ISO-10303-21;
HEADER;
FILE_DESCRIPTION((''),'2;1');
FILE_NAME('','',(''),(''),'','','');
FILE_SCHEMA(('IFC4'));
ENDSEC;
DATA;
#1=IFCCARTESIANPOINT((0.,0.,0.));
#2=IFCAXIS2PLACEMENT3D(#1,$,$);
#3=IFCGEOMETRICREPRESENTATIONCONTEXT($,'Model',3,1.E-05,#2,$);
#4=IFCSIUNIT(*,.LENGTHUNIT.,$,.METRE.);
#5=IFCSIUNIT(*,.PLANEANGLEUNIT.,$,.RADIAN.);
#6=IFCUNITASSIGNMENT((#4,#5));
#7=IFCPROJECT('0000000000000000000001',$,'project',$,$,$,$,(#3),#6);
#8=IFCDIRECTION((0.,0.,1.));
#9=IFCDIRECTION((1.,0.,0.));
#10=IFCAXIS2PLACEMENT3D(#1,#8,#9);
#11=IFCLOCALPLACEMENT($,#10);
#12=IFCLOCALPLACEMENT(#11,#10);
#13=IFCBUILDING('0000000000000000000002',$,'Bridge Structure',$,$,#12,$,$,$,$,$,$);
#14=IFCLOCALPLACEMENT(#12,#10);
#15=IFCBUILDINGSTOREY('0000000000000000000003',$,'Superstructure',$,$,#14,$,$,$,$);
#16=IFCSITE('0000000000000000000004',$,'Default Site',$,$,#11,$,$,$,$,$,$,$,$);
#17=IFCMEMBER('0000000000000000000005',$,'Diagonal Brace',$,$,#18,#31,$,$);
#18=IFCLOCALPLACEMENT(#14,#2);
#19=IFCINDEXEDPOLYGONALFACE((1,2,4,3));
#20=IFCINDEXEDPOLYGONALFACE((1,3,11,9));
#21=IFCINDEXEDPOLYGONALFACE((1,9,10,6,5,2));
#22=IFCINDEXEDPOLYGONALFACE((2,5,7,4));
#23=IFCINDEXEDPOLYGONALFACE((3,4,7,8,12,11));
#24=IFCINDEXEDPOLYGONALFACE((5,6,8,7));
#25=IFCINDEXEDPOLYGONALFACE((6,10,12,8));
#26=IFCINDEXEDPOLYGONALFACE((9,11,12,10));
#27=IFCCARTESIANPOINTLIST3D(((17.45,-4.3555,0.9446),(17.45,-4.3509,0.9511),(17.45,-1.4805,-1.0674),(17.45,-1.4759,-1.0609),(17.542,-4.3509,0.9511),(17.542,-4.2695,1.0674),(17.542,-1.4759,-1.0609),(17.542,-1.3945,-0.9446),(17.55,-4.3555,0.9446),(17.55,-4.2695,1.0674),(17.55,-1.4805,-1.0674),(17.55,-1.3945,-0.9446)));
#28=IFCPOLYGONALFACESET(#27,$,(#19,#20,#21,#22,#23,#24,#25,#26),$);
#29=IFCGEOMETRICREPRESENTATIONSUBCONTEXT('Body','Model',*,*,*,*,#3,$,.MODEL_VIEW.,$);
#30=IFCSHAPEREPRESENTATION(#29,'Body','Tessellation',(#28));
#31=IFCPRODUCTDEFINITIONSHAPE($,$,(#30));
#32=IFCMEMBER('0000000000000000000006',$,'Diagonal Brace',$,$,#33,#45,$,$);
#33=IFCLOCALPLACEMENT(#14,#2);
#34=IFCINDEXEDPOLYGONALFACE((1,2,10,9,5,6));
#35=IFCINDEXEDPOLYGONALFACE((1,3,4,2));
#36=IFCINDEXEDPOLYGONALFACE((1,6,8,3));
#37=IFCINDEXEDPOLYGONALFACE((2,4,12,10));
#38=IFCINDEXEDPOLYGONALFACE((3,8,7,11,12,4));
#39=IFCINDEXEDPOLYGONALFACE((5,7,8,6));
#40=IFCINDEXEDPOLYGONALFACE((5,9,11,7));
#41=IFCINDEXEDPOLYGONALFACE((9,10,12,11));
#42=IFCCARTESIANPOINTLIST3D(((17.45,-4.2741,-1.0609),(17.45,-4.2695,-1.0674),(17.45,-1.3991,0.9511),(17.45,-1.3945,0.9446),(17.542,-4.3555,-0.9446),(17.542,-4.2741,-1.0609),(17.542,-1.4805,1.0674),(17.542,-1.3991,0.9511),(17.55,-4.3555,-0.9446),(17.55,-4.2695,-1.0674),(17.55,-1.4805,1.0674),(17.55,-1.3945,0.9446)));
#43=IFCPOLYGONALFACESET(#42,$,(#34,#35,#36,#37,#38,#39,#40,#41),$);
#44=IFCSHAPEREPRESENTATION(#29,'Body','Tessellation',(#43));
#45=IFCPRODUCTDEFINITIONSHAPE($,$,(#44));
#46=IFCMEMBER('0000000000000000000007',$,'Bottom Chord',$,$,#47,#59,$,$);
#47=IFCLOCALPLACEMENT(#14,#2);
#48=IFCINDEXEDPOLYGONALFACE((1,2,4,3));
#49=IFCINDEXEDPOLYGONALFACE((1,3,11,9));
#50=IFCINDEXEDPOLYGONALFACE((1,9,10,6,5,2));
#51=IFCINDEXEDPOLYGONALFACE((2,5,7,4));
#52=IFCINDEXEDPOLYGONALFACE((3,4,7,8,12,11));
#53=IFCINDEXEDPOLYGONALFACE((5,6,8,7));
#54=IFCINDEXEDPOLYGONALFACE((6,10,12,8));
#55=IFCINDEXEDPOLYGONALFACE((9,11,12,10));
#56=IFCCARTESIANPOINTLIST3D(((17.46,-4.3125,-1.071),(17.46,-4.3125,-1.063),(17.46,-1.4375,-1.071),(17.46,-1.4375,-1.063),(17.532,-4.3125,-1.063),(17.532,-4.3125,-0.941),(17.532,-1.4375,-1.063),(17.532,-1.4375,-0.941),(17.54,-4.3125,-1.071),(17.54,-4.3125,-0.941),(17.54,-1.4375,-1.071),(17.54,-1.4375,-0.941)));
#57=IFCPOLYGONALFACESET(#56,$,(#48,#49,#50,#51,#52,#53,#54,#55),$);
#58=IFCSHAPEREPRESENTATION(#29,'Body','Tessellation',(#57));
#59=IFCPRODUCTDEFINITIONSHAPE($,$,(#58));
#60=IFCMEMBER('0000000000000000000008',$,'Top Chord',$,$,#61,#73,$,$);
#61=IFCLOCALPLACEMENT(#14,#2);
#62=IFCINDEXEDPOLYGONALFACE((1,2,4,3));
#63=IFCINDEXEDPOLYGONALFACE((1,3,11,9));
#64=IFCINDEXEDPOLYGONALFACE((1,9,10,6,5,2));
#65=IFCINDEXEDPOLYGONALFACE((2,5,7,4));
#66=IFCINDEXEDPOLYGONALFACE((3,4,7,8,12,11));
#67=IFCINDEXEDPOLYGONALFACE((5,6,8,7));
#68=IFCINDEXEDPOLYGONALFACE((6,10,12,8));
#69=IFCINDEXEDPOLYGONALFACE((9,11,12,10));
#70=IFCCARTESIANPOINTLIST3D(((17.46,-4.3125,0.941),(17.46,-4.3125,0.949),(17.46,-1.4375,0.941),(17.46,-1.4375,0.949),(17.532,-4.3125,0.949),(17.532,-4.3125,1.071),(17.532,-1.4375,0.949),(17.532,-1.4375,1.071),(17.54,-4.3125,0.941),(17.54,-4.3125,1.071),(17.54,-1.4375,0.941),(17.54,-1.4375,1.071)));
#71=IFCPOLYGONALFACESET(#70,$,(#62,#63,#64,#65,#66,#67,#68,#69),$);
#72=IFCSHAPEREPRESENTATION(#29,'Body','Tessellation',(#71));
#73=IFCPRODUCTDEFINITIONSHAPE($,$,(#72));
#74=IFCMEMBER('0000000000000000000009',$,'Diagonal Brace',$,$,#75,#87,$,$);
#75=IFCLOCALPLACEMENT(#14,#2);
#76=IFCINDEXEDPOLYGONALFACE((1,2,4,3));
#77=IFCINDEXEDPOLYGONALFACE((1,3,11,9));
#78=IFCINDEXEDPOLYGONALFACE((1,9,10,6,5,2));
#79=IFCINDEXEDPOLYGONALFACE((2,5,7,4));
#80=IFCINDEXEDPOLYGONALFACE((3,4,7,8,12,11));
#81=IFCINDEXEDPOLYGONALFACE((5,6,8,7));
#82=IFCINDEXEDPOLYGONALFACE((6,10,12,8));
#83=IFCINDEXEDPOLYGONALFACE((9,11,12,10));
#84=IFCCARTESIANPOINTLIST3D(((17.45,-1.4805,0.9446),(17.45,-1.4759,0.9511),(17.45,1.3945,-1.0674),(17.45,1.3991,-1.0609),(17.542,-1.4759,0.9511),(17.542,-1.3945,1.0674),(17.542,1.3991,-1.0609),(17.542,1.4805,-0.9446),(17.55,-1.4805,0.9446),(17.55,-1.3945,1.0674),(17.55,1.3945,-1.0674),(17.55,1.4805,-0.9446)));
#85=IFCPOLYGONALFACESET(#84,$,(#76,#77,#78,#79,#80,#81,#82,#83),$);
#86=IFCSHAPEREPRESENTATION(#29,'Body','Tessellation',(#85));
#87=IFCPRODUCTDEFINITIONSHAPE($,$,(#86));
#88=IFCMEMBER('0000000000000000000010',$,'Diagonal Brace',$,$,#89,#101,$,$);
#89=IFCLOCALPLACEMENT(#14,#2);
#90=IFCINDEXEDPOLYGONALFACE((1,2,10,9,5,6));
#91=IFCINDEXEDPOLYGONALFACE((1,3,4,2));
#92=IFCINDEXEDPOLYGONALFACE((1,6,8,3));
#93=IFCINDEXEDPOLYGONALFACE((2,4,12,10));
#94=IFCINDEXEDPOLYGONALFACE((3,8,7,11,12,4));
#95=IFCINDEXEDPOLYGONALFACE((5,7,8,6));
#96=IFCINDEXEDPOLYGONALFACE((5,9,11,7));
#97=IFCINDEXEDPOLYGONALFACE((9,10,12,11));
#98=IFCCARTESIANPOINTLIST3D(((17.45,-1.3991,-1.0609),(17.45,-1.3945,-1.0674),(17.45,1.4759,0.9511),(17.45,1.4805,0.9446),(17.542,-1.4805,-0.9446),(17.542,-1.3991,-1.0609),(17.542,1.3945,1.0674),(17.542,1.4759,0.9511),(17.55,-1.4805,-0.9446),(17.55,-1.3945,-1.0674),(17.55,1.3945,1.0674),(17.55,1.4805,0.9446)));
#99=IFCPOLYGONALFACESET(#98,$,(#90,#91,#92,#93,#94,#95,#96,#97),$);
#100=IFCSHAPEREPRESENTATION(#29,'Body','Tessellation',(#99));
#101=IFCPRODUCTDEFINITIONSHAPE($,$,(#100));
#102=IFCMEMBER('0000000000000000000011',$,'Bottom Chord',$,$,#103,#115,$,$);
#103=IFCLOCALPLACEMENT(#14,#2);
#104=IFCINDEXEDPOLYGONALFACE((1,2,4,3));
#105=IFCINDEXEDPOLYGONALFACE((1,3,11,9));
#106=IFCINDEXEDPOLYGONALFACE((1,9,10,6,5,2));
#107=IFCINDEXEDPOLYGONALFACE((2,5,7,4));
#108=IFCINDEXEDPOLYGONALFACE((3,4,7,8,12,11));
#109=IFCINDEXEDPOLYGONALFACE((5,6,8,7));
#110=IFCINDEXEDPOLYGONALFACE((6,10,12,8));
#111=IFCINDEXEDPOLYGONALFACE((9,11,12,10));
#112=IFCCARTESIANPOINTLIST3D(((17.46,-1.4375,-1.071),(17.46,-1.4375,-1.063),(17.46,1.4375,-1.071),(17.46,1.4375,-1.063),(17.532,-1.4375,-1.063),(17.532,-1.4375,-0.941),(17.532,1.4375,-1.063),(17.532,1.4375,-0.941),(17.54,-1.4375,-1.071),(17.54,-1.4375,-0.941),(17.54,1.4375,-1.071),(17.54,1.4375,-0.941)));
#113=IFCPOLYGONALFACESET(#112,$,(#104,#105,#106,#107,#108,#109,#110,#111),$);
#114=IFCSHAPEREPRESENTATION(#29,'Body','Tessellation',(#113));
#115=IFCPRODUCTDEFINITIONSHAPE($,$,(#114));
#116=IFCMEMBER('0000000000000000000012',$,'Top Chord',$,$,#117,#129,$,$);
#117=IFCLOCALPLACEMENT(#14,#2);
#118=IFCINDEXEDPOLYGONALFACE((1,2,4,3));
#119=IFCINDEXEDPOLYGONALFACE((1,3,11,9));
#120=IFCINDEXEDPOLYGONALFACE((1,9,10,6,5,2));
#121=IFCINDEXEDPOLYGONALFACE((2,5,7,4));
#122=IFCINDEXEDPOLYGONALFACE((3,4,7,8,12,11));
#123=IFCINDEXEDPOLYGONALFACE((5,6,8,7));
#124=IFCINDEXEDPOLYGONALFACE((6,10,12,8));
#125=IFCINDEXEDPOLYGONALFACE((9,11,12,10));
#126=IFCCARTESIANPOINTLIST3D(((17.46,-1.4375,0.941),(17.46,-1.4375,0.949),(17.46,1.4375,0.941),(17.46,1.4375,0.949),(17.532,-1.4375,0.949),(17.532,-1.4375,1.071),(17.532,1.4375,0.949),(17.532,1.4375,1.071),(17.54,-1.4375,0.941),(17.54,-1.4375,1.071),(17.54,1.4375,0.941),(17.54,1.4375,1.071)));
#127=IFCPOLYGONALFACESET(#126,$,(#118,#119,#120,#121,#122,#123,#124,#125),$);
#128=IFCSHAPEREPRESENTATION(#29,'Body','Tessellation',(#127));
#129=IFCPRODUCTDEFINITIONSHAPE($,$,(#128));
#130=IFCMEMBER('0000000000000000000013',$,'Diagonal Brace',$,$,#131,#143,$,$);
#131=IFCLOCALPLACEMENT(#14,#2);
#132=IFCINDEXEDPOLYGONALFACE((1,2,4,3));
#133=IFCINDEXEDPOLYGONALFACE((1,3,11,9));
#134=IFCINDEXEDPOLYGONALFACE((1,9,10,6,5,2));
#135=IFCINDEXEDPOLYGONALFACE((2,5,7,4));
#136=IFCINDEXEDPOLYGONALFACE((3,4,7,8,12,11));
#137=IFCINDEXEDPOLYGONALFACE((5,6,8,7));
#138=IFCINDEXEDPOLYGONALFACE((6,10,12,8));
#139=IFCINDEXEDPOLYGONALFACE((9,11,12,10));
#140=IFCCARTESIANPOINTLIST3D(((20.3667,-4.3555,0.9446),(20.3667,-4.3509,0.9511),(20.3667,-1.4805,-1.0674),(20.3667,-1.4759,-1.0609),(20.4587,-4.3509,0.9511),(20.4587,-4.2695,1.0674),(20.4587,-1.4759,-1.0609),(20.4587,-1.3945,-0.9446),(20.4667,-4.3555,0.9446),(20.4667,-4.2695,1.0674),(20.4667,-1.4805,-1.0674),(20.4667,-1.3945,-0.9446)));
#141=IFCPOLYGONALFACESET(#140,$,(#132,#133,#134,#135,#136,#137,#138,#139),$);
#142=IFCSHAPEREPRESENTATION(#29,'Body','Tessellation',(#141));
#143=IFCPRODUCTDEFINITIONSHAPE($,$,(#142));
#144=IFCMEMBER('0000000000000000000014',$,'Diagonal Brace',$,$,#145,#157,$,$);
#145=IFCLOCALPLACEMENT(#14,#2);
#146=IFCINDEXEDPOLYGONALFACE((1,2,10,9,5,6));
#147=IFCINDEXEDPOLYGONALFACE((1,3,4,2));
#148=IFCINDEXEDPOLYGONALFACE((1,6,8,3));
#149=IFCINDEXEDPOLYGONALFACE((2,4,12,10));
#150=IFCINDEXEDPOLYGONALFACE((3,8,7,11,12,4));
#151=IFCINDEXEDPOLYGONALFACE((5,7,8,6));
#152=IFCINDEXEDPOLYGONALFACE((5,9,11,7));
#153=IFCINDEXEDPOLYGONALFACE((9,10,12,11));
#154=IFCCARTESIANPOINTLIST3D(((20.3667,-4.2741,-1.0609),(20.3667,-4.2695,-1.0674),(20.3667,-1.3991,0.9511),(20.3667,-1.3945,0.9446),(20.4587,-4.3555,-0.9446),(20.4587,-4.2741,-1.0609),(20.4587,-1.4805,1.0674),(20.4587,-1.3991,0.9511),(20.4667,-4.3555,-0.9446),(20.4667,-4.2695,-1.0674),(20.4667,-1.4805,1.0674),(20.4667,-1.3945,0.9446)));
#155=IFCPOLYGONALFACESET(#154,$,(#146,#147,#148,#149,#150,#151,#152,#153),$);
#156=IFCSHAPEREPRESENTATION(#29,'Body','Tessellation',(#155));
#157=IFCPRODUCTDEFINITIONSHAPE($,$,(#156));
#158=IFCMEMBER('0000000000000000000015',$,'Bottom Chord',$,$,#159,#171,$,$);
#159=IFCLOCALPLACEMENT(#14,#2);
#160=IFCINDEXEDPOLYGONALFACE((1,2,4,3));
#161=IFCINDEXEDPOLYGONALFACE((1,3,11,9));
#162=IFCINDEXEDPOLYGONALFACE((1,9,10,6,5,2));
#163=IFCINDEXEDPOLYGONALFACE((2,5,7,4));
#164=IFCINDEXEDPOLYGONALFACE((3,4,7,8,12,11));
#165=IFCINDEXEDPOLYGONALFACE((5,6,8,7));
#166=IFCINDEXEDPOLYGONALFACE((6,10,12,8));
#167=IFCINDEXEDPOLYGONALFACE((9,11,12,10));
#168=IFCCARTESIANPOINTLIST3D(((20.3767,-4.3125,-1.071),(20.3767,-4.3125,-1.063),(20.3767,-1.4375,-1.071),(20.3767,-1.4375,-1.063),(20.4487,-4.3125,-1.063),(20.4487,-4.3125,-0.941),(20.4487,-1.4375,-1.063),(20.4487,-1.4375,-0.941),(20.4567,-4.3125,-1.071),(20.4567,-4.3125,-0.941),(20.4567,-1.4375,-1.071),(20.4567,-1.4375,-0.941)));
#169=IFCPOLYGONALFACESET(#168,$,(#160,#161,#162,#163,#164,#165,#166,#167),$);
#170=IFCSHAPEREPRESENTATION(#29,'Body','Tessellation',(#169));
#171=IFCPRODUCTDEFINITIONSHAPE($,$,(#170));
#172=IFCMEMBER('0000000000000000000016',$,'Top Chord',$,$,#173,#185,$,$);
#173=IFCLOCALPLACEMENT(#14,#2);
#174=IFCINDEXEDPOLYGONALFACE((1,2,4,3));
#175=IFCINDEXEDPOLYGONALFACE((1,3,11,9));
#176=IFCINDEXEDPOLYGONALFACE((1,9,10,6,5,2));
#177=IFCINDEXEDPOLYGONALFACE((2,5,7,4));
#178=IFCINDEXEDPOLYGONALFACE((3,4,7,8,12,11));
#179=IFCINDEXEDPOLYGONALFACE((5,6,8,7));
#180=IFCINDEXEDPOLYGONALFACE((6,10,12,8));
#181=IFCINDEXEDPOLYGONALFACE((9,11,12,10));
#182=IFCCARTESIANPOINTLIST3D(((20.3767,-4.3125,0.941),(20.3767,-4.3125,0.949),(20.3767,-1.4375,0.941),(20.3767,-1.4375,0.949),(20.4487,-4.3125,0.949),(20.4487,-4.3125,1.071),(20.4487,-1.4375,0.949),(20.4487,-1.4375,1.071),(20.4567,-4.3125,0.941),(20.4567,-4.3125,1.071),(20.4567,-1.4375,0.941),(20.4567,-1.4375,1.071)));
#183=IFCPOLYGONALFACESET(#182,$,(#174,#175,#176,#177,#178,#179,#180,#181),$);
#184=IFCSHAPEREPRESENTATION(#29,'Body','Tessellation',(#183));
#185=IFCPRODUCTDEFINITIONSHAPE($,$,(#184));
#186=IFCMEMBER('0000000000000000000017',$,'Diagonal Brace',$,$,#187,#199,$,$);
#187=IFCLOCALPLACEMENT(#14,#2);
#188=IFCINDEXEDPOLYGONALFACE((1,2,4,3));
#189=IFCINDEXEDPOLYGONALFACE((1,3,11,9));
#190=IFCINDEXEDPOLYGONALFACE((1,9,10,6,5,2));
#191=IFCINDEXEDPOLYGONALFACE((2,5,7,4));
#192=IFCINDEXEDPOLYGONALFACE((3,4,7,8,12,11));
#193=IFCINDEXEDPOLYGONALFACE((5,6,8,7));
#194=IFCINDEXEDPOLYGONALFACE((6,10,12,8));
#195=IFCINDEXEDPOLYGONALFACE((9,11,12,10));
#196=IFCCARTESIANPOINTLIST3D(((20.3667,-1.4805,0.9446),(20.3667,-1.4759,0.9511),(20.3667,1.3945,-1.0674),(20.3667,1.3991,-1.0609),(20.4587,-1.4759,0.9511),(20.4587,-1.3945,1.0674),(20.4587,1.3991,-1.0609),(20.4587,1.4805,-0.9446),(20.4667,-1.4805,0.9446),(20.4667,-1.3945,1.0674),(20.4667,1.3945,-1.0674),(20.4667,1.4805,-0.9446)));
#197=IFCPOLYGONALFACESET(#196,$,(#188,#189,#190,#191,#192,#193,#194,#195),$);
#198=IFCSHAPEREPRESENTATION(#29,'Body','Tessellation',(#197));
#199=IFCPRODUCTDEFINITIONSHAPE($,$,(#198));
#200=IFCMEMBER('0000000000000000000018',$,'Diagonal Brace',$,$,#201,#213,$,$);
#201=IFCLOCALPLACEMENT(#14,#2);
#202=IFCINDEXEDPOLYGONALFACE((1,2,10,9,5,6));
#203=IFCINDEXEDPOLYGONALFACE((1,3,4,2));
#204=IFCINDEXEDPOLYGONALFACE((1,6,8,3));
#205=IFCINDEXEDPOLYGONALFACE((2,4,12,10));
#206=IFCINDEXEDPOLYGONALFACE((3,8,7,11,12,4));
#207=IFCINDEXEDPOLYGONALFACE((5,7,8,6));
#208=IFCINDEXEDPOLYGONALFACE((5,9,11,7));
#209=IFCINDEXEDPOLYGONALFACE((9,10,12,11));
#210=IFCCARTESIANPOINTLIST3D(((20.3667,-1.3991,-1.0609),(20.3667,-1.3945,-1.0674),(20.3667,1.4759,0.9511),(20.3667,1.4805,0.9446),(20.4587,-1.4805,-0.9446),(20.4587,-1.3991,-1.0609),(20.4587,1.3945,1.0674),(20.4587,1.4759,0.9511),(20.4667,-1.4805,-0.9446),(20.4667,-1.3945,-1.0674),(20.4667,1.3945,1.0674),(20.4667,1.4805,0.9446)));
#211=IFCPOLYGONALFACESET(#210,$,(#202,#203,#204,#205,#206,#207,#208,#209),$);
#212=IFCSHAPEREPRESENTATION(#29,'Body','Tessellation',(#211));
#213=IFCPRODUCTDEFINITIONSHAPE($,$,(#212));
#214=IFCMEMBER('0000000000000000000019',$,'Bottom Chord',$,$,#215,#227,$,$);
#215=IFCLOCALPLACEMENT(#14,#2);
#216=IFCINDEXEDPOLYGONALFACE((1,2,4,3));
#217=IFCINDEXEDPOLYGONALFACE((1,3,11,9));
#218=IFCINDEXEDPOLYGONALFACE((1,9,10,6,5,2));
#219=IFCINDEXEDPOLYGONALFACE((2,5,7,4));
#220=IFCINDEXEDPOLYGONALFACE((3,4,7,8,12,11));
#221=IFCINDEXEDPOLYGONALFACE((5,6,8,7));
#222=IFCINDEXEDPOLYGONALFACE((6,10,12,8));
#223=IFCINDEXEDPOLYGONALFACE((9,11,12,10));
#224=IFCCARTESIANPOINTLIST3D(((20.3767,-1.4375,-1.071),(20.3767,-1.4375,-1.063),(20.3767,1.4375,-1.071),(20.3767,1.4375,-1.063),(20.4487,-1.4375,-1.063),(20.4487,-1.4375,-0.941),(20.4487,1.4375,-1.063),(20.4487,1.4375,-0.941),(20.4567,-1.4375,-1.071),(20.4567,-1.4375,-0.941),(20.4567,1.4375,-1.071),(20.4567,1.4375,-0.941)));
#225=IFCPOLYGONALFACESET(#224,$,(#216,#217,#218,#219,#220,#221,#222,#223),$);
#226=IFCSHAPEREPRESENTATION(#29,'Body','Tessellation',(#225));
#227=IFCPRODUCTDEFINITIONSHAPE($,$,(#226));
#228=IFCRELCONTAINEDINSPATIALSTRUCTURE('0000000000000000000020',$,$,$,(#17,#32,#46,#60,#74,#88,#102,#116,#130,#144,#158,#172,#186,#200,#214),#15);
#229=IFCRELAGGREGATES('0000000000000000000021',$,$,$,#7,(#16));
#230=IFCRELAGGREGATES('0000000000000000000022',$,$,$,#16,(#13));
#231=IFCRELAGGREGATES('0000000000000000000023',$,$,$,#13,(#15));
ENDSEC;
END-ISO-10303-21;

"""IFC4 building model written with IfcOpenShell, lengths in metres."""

from ifc_helpers import new_model, si_unit, frame, origin, origin_with_axes, origin_2d_with_axis, place, context, subcontext, project, spatial, l_section, extrude, element, save


model = new_model("IFC4")

# Units and contexts
model_context = context("Model", 3, precision=1e-05, world=origin())
body_context = subcontext(model_context, "Body", "Model", "MODEL_VIEW")
ifc_project = project(units=[si_unit("LENGTHUNIT", "METRE"), si_unit("PLANEANGLEUNIT", "RADIAN")], contexts=[model_context])

# Site, building, storey
site_placement = place(None, origin_with_axes())
site = spatial("IfcSite", under=ifc_project, at=site_placement, Name="Default Site")
building_placement = place(site_placement, origin_with_axes())
building = spatial("IfcBuilding", under=site, at=building_placement, Name="Bridge Structure")
storey_placement = place(building_placement, origin_with_axes())
storey = spatial("IfcBuildingStorey", under=building, at=storey_placement, Name="Superstructure")

# Members
for number, where, z_axis, x_axis, name in (
    (1, (17.5, -4.3125, 1.006), (0.0, 0.819299, -0.573367), (-1.0, 0.0, 0.0), "Diagonal Brace"),
    (2, (17.5, -4.3125, -1.006), (0.0, 0.819299, 0.573367), (-1.0, 0.0, 0.0), "Diagonal Brace"),
):
    element("IfcMember", number, at=place(storey_placement, frame(where, z_axis=z_axis, x_axis=x_axis)), inside=storey, Name=name, context=body_context, shape_type="SweptSolid", body=[
        extrude(l_section(Depth=0.15, Width=0.1, Thickness=0.008, at=origin_2d_with_axis()), origin_with_axes(), (0.0, 0.0, 1.0), 3.5091),
    ])
for number, where, z_axis, x_axis, name in (
    (3, (17.5, -4.3125, -1.006), (0.0, 1.0, 0.0), (-1.0, 0.0, 0.0), "Bottom Chord"),
    (4, (17.5, -4.3125, 1.006), (0.0, 1.0, 0.0), (-1.0, 0.0, 0.0), "Top Chord"),
):
    element("IfcMember", number, at=place(storey_placement, frame(where, z_axis=z_axis, x_axis=x_axis)), inside=storey, Name=name, context=body_context, shape_type="SweptSolid", body=[
        extrude(l_section(Depth=0.13, Width=0.08, Thickness=0.008, at=origin_2d_with_axis()), origin_with_axes(), (0.0, 0.0, 1.0), 2.875),
    ])
for number, where, z_axis, x_axis, name in (
    (5, (17.5, -1.4375, 1.006), (0.0, 0.819299, -0.573367), (-1.0, 0.0, 0.0), "Diagonal Brace"),
    (6, (17.5, -1.4375, -1.006), (0.0, 0.819299, 0.573367), (-1.0, 0.0, 0.0), "Diagonal Brace"),
):
    element("IfcMember", number, at=place(storey_placement, frame(where, z_axis=z_axis, x_axis=x_axis)), inside=storey, Name=name, context=body_context, shape_type="SweptSolid", body=[
        extrude(l_section(Depth=0.15, Width=0.1, Thickness=0.008, at=origin_2d_with_axis()), origin_with_axes(), (0.0, 0.0, 1.0), 3.5091),
    ])
for number, where, z_axis, x_axis, name in (
    (7, (17.5, -1.4375, -1.006), (0.0, 1.0, 0.0), (-1.0, 0.0, 0.0), "Bottom Chord"),
    (8, (17.5, -1.4375, 1.006), (0.0, 1.0, 0.0), (-1.0, 0.0, 0.0), "Top Chord"),
):
    element("IfcMember", number, at=place(storey_placement, frame(where, z_axis=z_axis, x_axis=x_axis)), inside=storey, Name=name, context=body_context, shape_type="SweptSolid", body=[
        extrude(l_section(Depth=0.13, Width=0.08, Thickness=0.008, at=origin_2d_with_axis()), origin_with_axes(), (0.0, 0.0, 1.0), 2.875),
    ])
for number, where, z_axis, x_axis, name in (
    (9, (20.4167, -4.3125, 1.006), (0.0, 0.819299, -0.573367), (-1.0, 0.0, 0.0), "Diagonal Brace"),
    (10, (20.4167, -4.3125, -1.006), (0.0, 0.819299, 0.573367), (-1.0, 0.0, 0.0), "Diagonal Brace"),
):
    element("IfcMember", number, at=place(storey_placement, frame(where, z_axis=z_axis, x_axis=x_axis)), inside=storey, Name=name, context=body_context, shape_type="SweptSolid", body=[
        extrude(l_section(Depth=0.15, Width=0.1, Thickness=0.008, at=origin_2d_with_axis()), origin_with_axes(), (0.0, 0.0, 1.0), 3.5091),
    ])
for number, where, z_axis, x_axis, name in (
    (11, (20.4167, -4.3125, -1.006), (0.0, 1.0, 0.0), (-1.0, 0.0, 0.0), "Bottom Chord"),
    (12, (20.4167, -4.3125, 1.006), (0.0, 1.0, 0.0), (-1.0, 0.0, 0.0), "Top Chord"),
):
    element("IfcMember", number, at=place(storey_placement, frame(where, z_axis=z_axis, x_axis=x_axis)), inside=storey, Name=name, context=body_context, shape_type="SweptSolid", body=[
        extrude(l_section(Depth=0.13, Width=0.08, Thickness=0.008, at=origin_2d_with_axis()), origin_with_axes(), (0.0, 0.0, 1.0), 2.875),
    ])
for number, where, z_axis, x_axis, name in (
    (13, (20.4167, -1.4375, 1.006), (0.0, 0.819299, -0.573367), (-1.0, 0.0, 0.0), "Diagonal Brace"),
    (14, (20.4167, -1.4375, -1.006), (0.0, 0.819299, 0.573367), (-1.0, 0.0, 0.0), "Diagonal Brace"),
):
    element("IfcMember", number, at=place(storey_placement, frame(where, z_axis=z_axis, x_axis=x_axis)), inside=storey, Name=name, context=body_context, shape_type="SweptSolid", body=[
        extrude(l_section(Depth=0.15, Width=0.1, Thickness=0.008, at=origin_2d_with_axis()), origin_with_axes(), (0.0, 0.0, 1.0), 3.5091),
    ])
for number, where, z_axis, x_axis, name in (
    (15, (20.4167, -1.4375, -1.006), (0.0, 1.0, 0.0), (-1.0, 0.0, 0.0), "Bottom Chord"),
):
    element("IfcMember", number, at=place(storey_placement, frame(where, z_axis=z_axis, x_axis=x_axis)), inside=storey, Name=name, context=body_context, shape_type="SweptSolid", body=[
        extrude(l_section(Depth=0.13, Width=0.08, Thickness=0.008, at=origin_2d_with_axis()), origin_with_axes(), (0.0, 0.0, 1.0), 2.875),
    ])

save(model, "model.ifc")
